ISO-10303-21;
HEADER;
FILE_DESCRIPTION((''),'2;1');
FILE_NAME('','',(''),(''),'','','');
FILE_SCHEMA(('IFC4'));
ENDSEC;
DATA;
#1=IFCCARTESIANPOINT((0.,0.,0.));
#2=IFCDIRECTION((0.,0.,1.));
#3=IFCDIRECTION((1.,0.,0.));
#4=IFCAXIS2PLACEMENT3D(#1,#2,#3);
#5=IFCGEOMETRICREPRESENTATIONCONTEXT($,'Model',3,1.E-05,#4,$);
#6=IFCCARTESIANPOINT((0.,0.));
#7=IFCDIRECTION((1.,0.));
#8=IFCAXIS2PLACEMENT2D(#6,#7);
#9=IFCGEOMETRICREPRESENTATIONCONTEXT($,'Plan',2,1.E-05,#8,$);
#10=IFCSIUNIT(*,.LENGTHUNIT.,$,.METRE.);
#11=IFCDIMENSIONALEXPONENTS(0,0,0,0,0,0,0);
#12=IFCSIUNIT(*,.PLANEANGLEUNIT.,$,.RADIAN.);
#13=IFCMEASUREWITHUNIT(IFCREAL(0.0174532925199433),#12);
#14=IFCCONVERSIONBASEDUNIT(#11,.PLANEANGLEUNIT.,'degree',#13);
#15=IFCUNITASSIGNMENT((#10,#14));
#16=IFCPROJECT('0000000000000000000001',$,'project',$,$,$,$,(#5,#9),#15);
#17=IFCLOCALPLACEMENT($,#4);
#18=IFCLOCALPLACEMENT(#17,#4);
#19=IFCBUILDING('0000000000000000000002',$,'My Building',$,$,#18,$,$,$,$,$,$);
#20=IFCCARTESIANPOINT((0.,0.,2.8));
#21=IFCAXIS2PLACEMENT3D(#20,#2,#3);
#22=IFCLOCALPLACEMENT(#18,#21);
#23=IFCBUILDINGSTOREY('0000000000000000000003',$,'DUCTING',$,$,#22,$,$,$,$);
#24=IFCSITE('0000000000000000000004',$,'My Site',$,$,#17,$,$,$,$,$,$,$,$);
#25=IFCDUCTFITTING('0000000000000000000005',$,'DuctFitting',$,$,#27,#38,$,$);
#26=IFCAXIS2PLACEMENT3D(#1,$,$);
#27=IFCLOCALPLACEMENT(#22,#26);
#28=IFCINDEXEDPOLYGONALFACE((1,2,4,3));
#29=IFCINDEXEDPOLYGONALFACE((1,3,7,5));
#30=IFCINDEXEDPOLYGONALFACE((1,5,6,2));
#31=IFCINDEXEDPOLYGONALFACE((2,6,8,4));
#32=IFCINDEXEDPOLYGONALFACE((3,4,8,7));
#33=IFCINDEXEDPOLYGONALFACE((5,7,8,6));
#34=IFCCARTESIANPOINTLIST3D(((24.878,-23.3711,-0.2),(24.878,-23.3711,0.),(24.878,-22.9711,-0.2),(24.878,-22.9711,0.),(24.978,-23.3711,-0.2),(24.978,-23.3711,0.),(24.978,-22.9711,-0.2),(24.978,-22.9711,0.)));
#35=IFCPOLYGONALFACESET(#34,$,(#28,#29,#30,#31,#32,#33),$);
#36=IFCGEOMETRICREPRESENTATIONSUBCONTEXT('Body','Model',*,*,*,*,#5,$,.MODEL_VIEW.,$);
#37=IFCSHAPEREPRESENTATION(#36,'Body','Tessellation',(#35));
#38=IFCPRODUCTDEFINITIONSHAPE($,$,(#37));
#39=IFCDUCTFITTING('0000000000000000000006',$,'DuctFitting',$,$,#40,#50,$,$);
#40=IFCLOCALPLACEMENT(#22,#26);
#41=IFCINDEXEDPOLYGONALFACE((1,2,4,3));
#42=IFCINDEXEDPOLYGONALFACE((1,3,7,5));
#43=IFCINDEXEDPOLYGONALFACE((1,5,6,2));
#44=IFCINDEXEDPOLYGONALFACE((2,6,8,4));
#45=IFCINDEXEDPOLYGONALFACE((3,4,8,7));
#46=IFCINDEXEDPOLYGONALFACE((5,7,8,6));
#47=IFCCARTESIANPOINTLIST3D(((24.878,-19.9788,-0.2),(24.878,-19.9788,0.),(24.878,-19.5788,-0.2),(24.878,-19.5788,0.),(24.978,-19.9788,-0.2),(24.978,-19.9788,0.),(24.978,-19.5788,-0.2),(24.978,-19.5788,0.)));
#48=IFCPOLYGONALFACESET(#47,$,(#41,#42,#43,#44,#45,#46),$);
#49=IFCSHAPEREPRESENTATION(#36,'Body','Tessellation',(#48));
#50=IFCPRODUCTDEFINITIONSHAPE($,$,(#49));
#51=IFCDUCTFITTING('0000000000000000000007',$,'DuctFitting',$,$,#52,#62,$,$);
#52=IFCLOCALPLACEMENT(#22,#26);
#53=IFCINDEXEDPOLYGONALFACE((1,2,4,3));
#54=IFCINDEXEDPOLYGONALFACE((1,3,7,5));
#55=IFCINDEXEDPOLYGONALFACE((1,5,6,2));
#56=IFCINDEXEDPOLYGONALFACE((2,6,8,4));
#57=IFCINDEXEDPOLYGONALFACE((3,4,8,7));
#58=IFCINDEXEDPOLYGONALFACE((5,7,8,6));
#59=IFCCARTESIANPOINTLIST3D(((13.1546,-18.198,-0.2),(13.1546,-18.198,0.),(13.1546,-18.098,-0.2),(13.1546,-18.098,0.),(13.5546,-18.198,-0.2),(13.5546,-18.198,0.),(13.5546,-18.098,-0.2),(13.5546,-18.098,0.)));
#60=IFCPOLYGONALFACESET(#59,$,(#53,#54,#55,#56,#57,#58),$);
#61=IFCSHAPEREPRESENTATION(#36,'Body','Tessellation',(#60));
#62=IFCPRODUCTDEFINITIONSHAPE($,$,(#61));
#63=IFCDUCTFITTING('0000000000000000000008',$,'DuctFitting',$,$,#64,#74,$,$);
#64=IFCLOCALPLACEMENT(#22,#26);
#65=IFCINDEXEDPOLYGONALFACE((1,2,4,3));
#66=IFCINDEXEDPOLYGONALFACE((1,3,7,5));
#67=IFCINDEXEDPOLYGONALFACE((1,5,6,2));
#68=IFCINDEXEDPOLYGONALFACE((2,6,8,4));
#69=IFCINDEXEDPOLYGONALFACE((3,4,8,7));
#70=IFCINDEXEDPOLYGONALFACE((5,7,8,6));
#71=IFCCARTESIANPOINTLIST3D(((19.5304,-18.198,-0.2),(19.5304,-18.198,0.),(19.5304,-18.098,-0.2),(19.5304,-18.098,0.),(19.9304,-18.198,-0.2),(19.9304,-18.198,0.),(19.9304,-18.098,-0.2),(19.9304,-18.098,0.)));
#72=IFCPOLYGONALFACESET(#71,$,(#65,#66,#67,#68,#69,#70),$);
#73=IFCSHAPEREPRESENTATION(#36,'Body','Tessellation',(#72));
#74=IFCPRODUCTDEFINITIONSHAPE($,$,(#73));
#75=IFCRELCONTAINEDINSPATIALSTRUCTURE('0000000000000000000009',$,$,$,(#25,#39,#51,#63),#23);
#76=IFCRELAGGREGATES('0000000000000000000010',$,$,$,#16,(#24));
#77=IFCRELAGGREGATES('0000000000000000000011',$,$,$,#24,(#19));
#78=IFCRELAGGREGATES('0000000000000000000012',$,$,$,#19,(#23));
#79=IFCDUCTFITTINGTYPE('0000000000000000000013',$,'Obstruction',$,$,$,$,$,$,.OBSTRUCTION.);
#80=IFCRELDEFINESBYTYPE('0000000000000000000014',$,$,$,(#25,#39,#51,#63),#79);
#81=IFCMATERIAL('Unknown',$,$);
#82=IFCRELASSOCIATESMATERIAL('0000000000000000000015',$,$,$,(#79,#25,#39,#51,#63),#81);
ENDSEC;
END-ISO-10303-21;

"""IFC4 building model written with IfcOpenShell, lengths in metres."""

from ifc_helpers import new_model, entity, si_unit, converted_unit, frame, origin_with_axes, origin_2d_with_axis, place, context, subcontext, project, spatial, rectangle, extrude, material, material_profile, profile_set, profile_usage, type_object, element, save


model = new_model("IFC4")

# Units and contexts
model_context = context("Model", 3, precision=1e-05, world=origin_with_axes())
plan_context = context("Plan", 2, precision=1e-05, world=origin_2d_with_axis())
body_context = subcontext(model_context, "Body", "Model", "MODEL_VIEW")
ifc_project = project(units=[si_unit("LENGTHUNIT", "METRE"), converted_unit("PLANEANGLEUNIT", "degree", entity("IfcReal", 0.0174532925199433), si_unit("PLANEANGLEUNIT", "RADIAN"), dimensions=[0, 0, 0, 0, 0, 0, 0])], contexts=[model_context, plan_context])

# Site, building, storey
site_placement = place(None, origin_with_axes())
site = spatial("IfcSite", under=ifc_project, at=site_placement, Name="My Site")
building_placement = place(site_placement, origin_with_axes())
building = spatial("IfcBuilding", under=site, at=building_placement, Name="My Building")
storey_placement = place(building_placement, frame((0.0, 0.0, 2.8), z_axis=(0.0, 0.0, 1.0), x_axis=(1.0, 0.0, 0.0)))
storey = spatial("IfcBuildingStorey", under=building, at=storey_placement, Name="DUCTING")

# Shared definitions
ifc_material = material(Name="Unknown")

# Duct fittings
ifc_material_profile_1 = material_profile(ifc_material, rectangle(XDim=0.4, YDim=0.2))
ifc_profile_set_1 = profile_set([ifc_material_profile_1])
duct_fitting_type_1 = type_object("IfcDuctFittingType", Name="Obstruction", PredefinedType="OBSTRUCTION", material=ifc_profile_set_1)
ifc_profile_usage_1 = profile_usage(ifc_profile_set_1, cardinal=5)
duct_fitting_1_placement = place(storey_placement, frame((24.878, -23.1711, -0.1), z_axis=(1.0, 0.0, 0.0), x_axis=(0.0, 1.0, 0.0)))
element("IfcDuctFitting", 1, at=duct_fitting_1_placement, inside=storey, type_object=duct_fitting_type_1, material=ifc_profile_usage_1, Name="DuctFitting", context=body_context, shape_type="SweptSolid", body=[
    extrude(rectangle(XDim=0.4, YDim=0.2), origin_with_axes(), (0.0, 0.0, 1.0), 0.1),
])
ifc_profile_usage_2 = profile_usage(ifc_profile_set_1, cardinal=5)
duct_fitting_2_placement = place(storey_placement, frame((24.878, -19.7788, -0.1), z_axis=(1.0, 0.0, 0.0), x_axis=(0.0, 1.0, 0.0)))
element("IfcDuctFitting", 2, at=duct_fitting_2_placement, inside=storey, type_object=duct_fitting_type_1, material=ifc_profile_usage_2, Name="DuctFitting", context=body_context, shape_type="SweptSolid", body=[
    extrude(rectangle(XDim=0.4, YDim=0.2), origin_with_axes(), (0.0, 0.0, 1.0), 0.1),
])
ifc_profile_usage_3 = profile_usage(ifc_profile_set_1, cardinal=5)
duct_fitting_3_placement = place(storey_placement, frame((13.3546, -18.098, -0.1), z_axis=(0.0, -1.0, 0.0), x_axis=(1.0, 0.0, 0.0)))
element("IfcDuctFitting", 3, at=duct_fitting_3_placement, inside=storey, type_object=duct_fitting_type_1, material=ifc_profile_usage_3, Name="DuctFitting", context=body_context, shape_type="SweptSolid", body=[
    extrude(rectangle(XDim=0.4, YDim=0.2), origin_with_axes(), (0.0, 0.0, 1.0), 0.1),
])
ifc_profile_usage_4 = profile_usage(ifc_profile_set_1, cardinal=5)
duct_fitting_4_placement = place(storey_placement, frame((19.7304, -18.098, -0.1), z_axis=(0.0, -1.0, 0.0), x_axis=(1.0, 0.0, 0.0)))
element("IfcDuctFitting", 4, at=duct_fitting_4_placement, inside=storey, type_object=duct_fitting_type_1, material=ifc_profile_usage_4, Name="DuctFitting", context=body_context, shape_type="SweptSolid", body=[
    extrude(rectangle(XDim=0.4, YDim=0.2), origin_with_axes(), (0.0, 0.0, 1.0), 0.1),
])

save(model, "model.ifc")
